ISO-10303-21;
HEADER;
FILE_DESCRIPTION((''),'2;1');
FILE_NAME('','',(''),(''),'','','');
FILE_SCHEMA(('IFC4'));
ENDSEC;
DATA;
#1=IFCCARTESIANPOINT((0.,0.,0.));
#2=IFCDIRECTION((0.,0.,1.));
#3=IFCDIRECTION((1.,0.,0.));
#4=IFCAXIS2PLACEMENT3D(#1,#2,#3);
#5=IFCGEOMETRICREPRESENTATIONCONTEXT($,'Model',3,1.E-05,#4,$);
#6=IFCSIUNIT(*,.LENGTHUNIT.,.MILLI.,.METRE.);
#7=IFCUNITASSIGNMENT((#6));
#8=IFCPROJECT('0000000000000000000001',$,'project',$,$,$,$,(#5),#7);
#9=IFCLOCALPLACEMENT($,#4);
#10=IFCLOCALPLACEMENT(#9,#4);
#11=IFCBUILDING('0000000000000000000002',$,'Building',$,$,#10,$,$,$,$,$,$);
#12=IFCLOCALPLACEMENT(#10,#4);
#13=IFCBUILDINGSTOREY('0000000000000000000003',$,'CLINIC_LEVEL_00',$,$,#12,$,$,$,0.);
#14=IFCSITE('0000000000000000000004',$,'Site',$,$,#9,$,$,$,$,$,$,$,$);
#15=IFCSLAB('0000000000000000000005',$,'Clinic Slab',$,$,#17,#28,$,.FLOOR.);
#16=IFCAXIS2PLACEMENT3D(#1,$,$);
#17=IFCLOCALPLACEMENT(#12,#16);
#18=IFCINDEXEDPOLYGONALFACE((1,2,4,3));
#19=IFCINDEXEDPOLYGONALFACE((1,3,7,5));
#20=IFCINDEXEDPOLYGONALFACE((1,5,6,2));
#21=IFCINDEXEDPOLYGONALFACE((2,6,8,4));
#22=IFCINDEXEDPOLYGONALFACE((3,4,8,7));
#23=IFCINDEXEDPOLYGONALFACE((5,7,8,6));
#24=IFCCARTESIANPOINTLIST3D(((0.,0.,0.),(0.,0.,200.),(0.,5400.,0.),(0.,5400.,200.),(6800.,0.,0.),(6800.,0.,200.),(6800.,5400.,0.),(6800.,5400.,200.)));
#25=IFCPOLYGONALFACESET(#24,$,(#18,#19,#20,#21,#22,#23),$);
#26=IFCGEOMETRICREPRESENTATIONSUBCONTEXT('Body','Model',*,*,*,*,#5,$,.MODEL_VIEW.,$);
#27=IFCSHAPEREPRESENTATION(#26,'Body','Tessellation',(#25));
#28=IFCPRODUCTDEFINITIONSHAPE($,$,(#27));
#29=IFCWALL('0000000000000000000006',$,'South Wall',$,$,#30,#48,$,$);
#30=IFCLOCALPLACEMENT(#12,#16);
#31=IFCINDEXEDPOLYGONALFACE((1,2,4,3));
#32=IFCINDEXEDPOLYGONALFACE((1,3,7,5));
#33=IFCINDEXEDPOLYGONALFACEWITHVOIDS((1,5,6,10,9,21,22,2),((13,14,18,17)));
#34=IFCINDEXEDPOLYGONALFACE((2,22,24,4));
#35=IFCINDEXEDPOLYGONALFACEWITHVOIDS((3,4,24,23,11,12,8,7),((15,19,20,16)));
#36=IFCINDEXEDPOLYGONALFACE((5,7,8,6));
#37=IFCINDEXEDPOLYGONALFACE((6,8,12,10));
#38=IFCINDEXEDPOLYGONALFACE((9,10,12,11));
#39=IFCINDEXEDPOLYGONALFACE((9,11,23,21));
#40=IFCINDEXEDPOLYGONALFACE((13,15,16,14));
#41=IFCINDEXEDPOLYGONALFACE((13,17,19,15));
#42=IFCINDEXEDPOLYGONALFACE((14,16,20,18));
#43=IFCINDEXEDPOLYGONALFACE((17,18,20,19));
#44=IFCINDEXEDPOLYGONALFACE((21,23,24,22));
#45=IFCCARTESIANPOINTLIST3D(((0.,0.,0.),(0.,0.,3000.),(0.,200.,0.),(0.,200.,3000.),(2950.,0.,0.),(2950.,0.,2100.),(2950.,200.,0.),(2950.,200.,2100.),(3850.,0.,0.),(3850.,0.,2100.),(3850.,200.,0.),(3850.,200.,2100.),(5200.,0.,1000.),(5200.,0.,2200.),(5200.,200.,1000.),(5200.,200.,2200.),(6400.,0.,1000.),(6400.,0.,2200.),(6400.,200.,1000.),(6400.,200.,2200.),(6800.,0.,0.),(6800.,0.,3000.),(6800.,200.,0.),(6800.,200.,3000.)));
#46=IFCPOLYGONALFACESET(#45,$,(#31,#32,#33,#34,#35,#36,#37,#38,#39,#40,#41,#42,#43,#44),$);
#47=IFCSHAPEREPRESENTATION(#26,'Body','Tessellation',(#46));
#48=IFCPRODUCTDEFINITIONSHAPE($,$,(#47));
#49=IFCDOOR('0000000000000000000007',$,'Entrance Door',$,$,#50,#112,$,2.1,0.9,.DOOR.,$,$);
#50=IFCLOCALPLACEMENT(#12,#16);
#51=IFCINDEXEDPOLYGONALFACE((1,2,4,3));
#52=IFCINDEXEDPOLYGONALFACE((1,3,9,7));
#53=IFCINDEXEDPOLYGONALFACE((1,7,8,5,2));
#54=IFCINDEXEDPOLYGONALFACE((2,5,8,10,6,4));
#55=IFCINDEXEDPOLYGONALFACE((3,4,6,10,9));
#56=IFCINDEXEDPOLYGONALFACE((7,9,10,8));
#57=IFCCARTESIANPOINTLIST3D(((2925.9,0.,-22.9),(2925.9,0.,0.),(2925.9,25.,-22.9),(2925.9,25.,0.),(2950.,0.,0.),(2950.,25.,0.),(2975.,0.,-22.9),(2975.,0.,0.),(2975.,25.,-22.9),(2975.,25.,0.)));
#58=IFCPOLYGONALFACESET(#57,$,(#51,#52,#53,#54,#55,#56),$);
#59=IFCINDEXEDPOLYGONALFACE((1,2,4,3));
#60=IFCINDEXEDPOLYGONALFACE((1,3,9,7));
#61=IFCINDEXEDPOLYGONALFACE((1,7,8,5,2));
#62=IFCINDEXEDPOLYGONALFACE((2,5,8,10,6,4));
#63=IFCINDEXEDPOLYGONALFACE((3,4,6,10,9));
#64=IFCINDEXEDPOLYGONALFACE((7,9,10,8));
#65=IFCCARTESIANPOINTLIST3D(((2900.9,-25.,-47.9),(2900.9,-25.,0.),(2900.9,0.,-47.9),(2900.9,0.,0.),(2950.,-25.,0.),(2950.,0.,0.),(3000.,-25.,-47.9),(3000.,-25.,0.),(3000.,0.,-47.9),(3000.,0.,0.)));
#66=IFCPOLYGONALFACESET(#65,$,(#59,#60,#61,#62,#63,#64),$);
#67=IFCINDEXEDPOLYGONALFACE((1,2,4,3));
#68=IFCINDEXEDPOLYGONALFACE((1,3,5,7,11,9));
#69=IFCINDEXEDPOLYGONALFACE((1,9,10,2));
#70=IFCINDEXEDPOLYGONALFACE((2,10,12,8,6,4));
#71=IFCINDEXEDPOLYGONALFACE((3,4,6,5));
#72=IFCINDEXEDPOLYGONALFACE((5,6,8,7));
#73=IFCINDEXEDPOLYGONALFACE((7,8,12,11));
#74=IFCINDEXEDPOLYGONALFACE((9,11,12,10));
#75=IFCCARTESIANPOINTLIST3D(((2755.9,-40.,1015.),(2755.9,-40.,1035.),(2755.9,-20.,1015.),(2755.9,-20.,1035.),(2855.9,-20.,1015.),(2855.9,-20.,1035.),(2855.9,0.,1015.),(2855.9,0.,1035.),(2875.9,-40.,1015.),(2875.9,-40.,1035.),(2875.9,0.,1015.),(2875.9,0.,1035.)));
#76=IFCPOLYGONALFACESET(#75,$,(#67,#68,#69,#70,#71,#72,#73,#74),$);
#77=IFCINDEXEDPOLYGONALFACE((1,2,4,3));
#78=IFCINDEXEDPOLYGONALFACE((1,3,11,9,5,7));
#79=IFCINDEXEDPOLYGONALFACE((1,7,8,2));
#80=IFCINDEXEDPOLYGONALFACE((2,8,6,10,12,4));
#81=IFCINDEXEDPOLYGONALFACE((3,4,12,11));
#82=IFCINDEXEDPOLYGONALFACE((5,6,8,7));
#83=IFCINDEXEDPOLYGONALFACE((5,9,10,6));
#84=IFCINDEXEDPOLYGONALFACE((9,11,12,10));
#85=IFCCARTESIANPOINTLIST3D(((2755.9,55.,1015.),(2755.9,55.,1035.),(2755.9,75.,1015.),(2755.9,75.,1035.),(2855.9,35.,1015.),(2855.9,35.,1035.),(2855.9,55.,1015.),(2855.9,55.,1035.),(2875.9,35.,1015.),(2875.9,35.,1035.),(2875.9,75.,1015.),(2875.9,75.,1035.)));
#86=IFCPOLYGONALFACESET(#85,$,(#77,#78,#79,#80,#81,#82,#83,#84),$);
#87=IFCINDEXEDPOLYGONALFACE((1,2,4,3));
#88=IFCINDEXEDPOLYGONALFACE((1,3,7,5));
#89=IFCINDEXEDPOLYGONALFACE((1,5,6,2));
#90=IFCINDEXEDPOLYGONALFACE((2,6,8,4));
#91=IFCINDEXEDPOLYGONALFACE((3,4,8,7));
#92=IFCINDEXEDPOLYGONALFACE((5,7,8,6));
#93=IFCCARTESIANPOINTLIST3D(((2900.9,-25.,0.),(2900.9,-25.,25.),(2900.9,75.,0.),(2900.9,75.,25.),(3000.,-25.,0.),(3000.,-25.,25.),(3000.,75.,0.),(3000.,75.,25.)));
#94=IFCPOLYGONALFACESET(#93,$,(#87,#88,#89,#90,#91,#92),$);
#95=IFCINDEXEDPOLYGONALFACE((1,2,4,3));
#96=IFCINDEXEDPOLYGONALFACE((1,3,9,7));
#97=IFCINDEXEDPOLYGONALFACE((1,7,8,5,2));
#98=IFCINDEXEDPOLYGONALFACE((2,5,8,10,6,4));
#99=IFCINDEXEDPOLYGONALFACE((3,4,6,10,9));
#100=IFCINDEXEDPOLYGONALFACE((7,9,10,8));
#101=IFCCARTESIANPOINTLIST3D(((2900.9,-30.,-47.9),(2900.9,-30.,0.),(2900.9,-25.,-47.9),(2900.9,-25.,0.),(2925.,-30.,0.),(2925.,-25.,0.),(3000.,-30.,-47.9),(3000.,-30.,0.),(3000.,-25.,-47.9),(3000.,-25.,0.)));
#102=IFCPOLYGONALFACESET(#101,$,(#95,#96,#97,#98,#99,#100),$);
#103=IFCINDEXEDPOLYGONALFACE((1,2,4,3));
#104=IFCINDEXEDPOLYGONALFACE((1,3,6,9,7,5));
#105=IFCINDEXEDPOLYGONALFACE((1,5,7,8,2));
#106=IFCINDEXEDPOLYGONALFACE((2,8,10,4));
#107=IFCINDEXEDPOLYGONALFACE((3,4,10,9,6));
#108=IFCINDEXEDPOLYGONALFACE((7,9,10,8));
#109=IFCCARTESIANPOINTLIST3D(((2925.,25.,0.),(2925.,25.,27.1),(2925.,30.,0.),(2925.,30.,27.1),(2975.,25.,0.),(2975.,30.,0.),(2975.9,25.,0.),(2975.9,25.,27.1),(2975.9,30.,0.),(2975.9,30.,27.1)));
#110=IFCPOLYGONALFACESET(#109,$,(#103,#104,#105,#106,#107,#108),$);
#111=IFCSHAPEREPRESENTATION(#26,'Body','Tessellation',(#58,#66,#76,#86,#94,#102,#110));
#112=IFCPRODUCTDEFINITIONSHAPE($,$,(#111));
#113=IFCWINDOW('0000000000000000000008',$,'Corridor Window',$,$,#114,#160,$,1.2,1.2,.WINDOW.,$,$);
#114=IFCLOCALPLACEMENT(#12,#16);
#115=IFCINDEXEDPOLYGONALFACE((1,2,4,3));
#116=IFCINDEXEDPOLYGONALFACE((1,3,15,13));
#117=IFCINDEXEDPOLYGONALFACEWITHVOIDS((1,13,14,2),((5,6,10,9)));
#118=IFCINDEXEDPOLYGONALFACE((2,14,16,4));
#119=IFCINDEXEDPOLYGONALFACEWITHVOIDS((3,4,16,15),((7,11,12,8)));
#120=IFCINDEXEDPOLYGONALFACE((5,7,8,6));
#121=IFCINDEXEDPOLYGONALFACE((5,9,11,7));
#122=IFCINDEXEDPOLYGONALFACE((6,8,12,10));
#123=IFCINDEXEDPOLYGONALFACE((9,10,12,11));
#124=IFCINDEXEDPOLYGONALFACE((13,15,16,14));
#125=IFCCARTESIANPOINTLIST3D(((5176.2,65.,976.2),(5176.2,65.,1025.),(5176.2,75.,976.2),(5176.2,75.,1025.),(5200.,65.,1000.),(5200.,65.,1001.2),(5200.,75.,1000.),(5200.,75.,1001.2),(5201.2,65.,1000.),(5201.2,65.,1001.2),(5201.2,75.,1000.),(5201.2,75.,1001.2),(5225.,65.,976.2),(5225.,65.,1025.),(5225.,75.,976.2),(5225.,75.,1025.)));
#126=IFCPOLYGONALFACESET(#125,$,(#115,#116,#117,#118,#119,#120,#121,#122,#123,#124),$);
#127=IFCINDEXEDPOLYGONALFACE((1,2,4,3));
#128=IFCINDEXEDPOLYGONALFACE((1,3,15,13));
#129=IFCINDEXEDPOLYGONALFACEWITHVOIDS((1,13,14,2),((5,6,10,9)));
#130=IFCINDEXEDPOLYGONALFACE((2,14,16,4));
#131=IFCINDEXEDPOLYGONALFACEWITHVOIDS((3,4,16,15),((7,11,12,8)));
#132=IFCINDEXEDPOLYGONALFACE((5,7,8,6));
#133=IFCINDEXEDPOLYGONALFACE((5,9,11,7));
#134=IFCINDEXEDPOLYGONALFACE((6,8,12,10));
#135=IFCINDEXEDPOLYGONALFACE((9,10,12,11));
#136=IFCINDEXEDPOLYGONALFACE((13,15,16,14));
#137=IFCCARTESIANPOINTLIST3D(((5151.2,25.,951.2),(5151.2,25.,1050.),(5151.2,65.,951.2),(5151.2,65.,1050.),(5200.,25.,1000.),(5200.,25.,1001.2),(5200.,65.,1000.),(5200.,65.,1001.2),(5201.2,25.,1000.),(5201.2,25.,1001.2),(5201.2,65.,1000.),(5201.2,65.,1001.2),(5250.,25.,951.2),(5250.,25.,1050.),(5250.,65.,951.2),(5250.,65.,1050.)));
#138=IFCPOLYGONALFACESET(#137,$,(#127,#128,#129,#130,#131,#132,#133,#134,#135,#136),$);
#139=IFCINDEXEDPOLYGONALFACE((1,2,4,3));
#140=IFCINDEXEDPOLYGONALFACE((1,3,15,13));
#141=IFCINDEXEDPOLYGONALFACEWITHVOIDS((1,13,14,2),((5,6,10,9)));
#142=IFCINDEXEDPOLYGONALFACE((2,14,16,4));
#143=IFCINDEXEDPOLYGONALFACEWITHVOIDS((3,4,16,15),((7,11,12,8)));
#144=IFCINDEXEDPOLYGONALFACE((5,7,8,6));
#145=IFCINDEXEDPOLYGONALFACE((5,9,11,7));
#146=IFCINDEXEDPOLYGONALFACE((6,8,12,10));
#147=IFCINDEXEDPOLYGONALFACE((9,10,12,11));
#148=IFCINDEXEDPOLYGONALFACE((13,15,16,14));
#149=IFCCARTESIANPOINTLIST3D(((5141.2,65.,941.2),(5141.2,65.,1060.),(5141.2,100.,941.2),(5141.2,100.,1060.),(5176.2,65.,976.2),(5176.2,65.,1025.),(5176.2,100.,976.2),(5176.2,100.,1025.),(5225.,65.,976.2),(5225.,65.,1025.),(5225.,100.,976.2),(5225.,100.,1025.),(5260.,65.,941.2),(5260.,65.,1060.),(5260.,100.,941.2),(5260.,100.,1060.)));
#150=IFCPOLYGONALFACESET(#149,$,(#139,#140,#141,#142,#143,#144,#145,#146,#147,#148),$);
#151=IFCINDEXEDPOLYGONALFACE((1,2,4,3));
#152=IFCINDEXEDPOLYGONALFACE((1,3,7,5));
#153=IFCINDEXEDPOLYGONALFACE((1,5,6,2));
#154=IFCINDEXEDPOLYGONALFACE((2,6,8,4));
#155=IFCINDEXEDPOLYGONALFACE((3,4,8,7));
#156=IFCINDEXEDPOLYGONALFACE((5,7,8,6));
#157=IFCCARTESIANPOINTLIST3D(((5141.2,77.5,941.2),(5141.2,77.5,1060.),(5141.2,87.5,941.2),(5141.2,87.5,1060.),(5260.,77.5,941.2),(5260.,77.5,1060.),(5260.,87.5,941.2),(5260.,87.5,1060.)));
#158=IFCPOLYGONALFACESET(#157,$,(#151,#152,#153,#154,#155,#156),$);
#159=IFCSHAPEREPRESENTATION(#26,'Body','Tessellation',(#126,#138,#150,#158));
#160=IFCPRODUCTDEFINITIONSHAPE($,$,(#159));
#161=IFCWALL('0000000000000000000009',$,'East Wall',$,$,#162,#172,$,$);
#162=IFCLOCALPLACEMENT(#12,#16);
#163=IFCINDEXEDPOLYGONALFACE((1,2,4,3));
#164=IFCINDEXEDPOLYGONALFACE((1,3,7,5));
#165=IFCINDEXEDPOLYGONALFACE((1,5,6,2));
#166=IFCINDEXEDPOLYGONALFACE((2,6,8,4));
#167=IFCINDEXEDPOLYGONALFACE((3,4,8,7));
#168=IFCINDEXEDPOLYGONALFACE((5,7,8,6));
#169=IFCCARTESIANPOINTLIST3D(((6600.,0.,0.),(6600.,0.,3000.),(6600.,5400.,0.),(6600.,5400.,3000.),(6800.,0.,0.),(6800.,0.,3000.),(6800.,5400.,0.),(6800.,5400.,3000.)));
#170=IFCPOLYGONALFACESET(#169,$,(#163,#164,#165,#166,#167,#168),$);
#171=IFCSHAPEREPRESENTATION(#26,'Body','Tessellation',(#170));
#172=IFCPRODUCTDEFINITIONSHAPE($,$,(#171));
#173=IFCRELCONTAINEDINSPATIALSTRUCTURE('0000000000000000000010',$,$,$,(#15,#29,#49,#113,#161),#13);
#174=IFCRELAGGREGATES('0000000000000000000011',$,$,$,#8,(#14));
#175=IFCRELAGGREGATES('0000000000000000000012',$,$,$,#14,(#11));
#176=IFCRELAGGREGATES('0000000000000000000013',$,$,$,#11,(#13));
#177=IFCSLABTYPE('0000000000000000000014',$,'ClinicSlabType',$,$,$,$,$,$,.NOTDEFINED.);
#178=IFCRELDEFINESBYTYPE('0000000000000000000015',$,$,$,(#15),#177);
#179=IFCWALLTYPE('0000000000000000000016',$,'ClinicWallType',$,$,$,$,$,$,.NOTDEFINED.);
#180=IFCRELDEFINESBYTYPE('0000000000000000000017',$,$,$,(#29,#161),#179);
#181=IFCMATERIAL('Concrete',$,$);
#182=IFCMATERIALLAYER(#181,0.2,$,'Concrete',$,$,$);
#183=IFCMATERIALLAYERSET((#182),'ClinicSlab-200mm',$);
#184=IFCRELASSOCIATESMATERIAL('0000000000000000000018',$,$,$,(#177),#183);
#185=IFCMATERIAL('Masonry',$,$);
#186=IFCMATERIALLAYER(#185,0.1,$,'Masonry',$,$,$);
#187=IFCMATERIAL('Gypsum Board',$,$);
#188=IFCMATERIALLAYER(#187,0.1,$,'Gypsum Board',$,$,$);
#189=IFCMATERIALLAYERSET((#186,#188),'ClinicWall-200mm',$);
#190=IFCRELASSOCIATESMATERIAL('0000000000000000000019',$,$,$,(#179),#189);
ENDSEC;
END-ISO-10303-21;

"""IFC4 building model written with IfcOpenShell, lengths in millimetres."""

from ifc_helpers import new_model, si_unit, frame, origin_with_axes, place, context, subcontext, project, spatial, line, indexed_curve, outline, extrude, material, layer, layer_set, type_object, element, fill, save


model = new_model("IFC4")

# Units and contexts
model_context = context("Model", 3, precision=1e-05, world=origin_with_axes())
body_context = subcontext(model_context, "Body", "Model", "MODEL_VIEW")
ifc_project = project(units=[si_unit("LENGTHUNIT", "METRE", prefix="MILLI")], contexts=[model_context])

# Site, building, storey
site_placement = place(None, origin_with_axes())
site = spatial("IfcSite", under=ifc_project, at=site_placement, Name="Site")
building_placement = place(site_placement, origin_with_axes())
building = spatial("IfcBuilding", under=site, at=building_placement, Name="Building")
storey_placement = place(building_placement, origin_with_axes())
storey = spatial("IfcBuildingStorey", under=building, at=storey_placement, Name="CLINIC_LEVEL_00", Elevation=0.0)

# Slab
ifc_material_1 = material(Name="Concrete")
ifc_layer_1 = layer(ifc_material_1, 0.2, Name="Concrete")
ifc_layer_set_1 = layer_set([ifc_layer_1], Name="ClinicSlab-200mm")
slab_type = type_object("IfcSlabType", Name="ClinicSlabType", PredefinedType="NOTDEFINED", material=ifc_layer_set_1)
slab_placement = place(storey_placement, origin_with_axes())
element("IfcSlab", 1, at=slab_placement, inside=storey, type_object=slab_type, Name="Clinic Slab", PredefinedType="FLOOR", context=body_context, shape_type="SweptSolid", body=[
    extrude(outline(indexed_curve([(0.0, 0.0), (6800.0, 0.0), (6800.0, 5400.0), (0.0, 5400.0), (0.0, 0.0)])), None, (0.0, 0.0, 1.0), 200.0),
])

# Wall, openings, door, window
ifc_material_2 = material(Name="Masonry")
ifc_layer_2 = layer(ifc_material_2, 0.1, Name="Masonry")
ifc_material_3 = material(Name="Gypsum Board")
ifc_layer_3 = layer(ifc_material_3, 0.1, Name="Gypsum Board")
ifc_layer_set_2 = layer_set([ifc_layer_2, ifc_layer_3], Name="ClinicWall-200mm")
wall_type = type_object("IfcWallType", Name="ClinicWallType", PredefinedType="NOTDEFINED", material=ifc_layer_set_2)
wall_1_placement = place(storey_placement, origin_with_axes())
wall_1 = element("IfcWall", 2, at=wall_1_placement, inside=storey, type_object=wall_type, Name="South Wall", context=body_context, shape_type="SweptSolid", body=[
    extrude(outline(indexed_curve([(0.0, 0.0), (0.0, 200.0), (6800.0, 200.0), (6800.0, 0.0), (0.0, 0.0)], self_intersect=False)), origin_with_axes(), (0.0, 0.0, 1.0), 3000.0),
])
opening_1_placement = place(wall_1_placement, frame((2950.0, -25.0, 0.0), z_axis=(0.0, 0.0, 1.0), x_axis=(1.0, 0.0, 0.0)))
opening_1 = element("IfcOpeningElement", 3, at=opening_1_placement, cuts=wall_1, context=body_context, shape_type="SweptSolid", body=[
    extrude(outline(indexed_curve([(0.0, 0.0), (0.0, 250.0), (900.0, 250.0), (900.0, 0.0), (0.0, 0.0)], self_intersect=False)), origin_with_axes(), (0.0, 0.0, 1.0), 2100.0),
])
opening_2_placement = place(wall_1_placement, frame((5200.0, -25.0, 1000.0), z_axis=(0.0, 0.0, 1.0), x_axis=(1.0, 0.0, 0.0)))
opening_2 = element("IfcOpeningElement", 4, at=opening_2_placement, cuts=wall_1, context=body_context, shape_type="SweptSolid", body=[
    extrude(outline(indexed_curve([(0.0, 0.0), (0.0, 250.0), (1200.0, 250.0), (1200.0, 0.0), (0.0, 0.0)], self_intersect=False)), origin_with_axes(), (0.0, 0.0, 1.0), 1200.0),
])
door_1_placement = place(storey_placement, frame((2950.0, -25.0, 0.0), z_axis=(0.0, 0.0, 1.0), x_axis=(1.0, 0.0, 0.0)))
door_1 = element("IfcDoor", 5, at=door_1_placement, inside=storey, Name="Entrance Door", OverallHeight=2.1, OverallWidth=0.9, PredefinedType="DOOR", context=body_context, shape_type="SweptSolid", body=[
    extrude(outline(indexed_curve([(0.0, 0.0), (0.0, 2.1), (0.9, 2.1), (0.9, 0.0), (-24.1, 0.0), (-24.1, -22.9), (25.0, -22.9), (25.0, 0.0)], segments=[line(1, 2, 3, 4, 5, 6, 7, 8, 1)])), frame((0.0, 25.0, 0.0), z_axis=(0.0, -1.0, 0.0), x_axis=(1.0, 0.0, 0.0)), (0.0, 0.0, -1.0), 25.0),
    extrude(outline(indexed_curve([(0.0, 0.0), (0.0, 2.1), (0.9, 2.1), (0.9, 0.0), (-49.1, 0.0), (-49.1, -47.9), (50.0, -47.9), (50.0, 0.0)], segments=[line(1, 2, 3, 4, 5, 6, 7, 8, 1)])), frame((0.0, 0.0, 0.0), z_axis=(0.0, -1.0, 0.0), x_axis=(1.0, 0.0, 0.0)), (0.0, 0.0, -1.0), 25.0),
    extrude(outline(indexed_curve([(0.0, 0.0), (-49.1, 0.0), (-49.1, 35.0), (0.0, 35.0)], segments=[line(1, 2, 3, 4, 1)])), frame((25.0, 25.0, 25.0), z_axis=(0.0, 0.0, 1.0), x_axis=(1.0, 0.0, 0.0)), (0.0, 0.0, 1.0), -47.9),
    extrude(outline(indexed_curve([(0.0, 0.0), (0.0, -40.0), (-120.0, -40.0), (-120.0, -20.0), (-20.0, -20.0), (-20.0, 0.0)], segments=[line(1, 2, 3, 4, 5, 6, 1)])), frame((-74.1, 25.0, 1015.0), z_axis=(0.0, 0.0, 1.0), x_axis=(1.0, 0.0, 0.0)), (0.0, 0.0, 1.0), 20.0),
    extrude(outline(indexed_curve([(0.0, 0.0), (0.0, 40.0), (-120.0, 40.0), (-120.0, 20.0), (-20.0, 20.0), (-20.0, 0.0)], segments=[line(1, 2, 3, 4, 5, 6, 1)])), frame((-74.1, 60.0, 1015.0), z_axis=(0.0, 0.0, 1.0), x_axis=(1.0, 0.0, 0.0)), (0.0, 0.0, 1.0), 20.0),
    extrude(outline(indexed_curve([(0.0, 0.0), (-99.1, 0.0), (-99.1, 100.0), (0.0, 100.0)], segments=[line(1, 2, 3, 4, 1)])), frame((50.0, 0.0, 0.0), z_axis=(0.0, 0.0, 1.0), x_axis=(1.0, 0.0, 0.0)), (0.0, 0.0, 1.0), 25.0),
    extrude(outline(indexed_curve([(0.0, 0.0), (0.0, 27.1), (50.9, 27.1), (50.9, 0.0), (-24.1, 0.0), (-24.1, -47.9), (75.0, -47.9), (75.0, 0.0)], segments=[line(1, 2, 3, 4, 5, 6, 7, 8, 1)])), frame((-25.0, -5.0, 0.0), z_axis=(0.0, -1.0, 0.0), x_axis=(1.0, 0.0, 0.0)), (0.0, 0.0, -1.0), 5.0),
    extrude(outline(indexed_curve([(0.0, 0.0), (0.0, 27.1), (50.9, 27.1), (50.9, 0.0), (0.9, 0.0), (0.9, -22.9), (50.0, -22.9), (50.0, 0.0)], segments=[line(1, 2, 3, 4, 5, 6, 7, 8, 1)])), frame((-25.0, 50.0, 0.0), z_axis=(0.0, -1.0, 0.0), x_axis=(1.0, 0.0, 0.0)), (0.0, 0.0, -1.0), 5.0),
])
fill(opening_1, door_1)
window_1_placement = place(storey_placement, frame((5200.0, -25.0, 1000.0), z_axis=(0.0, 0.0, 1.0), x_axis=(1.0, 0.0, 0.0)))
window_1 = element("IfcWindow", 6, at=window_1_placement, inside=storey, Name="Corridor Window", OverallHeight=1.2, OverallWidth=1.2, PredefinedType="WINDOW", context=body_context, shape_type="SweptSolid", body=[
    extrude(outline(indexed_curve([(0.0, 0.0), (1.2, 0.0), (1.2, 1.2), (0.0, 1.2)], segments=[line(1, 2, 3, 4, 1)]), holes=[indexed_curve([(25.0, 25.0), (-23.8, 25.0), (-23.8, -23.8), (25.0, -23.8)], segments=[line(1, 2, 3, 4, 1)])]), frame((0.0, 90.0, 0.0), z_axis=(0.0, -1.0, 0.0), x_axis=(1.0, 0.0, 0.0)), (0.0, 0.0, -1.0), 10.0),
    extrude(outline(indexed_curve([(0.0, 0.0), (1.2, 0.0), (1.2, 1.2), (0.0, 1.2)], segments=[line(1, 2, 3, 4, 1)]), holes=[indexed_curve([(50.0, 50.0), (-48.8, 50.0), (-48.8, -48.8), (50.0, -48.8)], segments=[line(1, 2, 3, 4, 1)])]), frame((0.0, 50.0, 0.0), z_axis=(0.0, -1.0, 0.0), x_axis=(1.0, 0.0, 0.0)), (0.0, 0.0, -1.0), 40.0),
    extrude(outline(indexed_curve([(0.0, 0.0), (-48.8, 0.0), (-48.8, -48.8), (0.0, -48.8)], segments=[line(1, 2, 3, 4, 1)]), holes=[indexed_curve([(35.0, 35.0), (-83.8, 35.0), (-83.8, -83.8), (35.0, -83.8)], segments=[line(1, 2, 3, 4, 1)])]), frame((25.0, 90.0, 25.0), z_axis=(0.0, -1.0, 0.0), x_axis=(1.0, 0.0, 0.0)), (0.0, 0.0, -1.0), 35.0),
    extrude(outline(indexed_curve([(35.0, 35.0), (-83.8, 35.0), (-83.8, -83.8), (35.0, -83.8)], segments=[line(1, 2, 3, 4, 1)])), frame((25.0, 102.5, 25.0), z_axis=(0.0, -1.0, 0.0), x_axis=(1.0, 0.0, 0.0)), (0.0, 0.0, -1.0), 10.0),
])
fill(opening_2, window_1)

# Wall
wall_2_placement = place(storey_placement, frame((6800.0, 0.0, 0.0), z_axis=(0.0, 0.0, 1.0), x_axis=(0.0, 1.0, 0.0)))
element("IfcWall", 7, at=wall_2_placement, inside=storey, type_object=wall_type, Name="East Wall", context=body_context, shape_type="SweptSolid", body=[
    extrude(outline(indexed_curve([(0.0, 0.0), (0.0, 200.0), (5400.0, 200.0), (5400.0, 0.0), (0.0, 0.0)], self_intersect=False)), origin_with_axes(), (0.0, 0.0, 1.0), 3000.0),
])

save(model, "model.ifc")
